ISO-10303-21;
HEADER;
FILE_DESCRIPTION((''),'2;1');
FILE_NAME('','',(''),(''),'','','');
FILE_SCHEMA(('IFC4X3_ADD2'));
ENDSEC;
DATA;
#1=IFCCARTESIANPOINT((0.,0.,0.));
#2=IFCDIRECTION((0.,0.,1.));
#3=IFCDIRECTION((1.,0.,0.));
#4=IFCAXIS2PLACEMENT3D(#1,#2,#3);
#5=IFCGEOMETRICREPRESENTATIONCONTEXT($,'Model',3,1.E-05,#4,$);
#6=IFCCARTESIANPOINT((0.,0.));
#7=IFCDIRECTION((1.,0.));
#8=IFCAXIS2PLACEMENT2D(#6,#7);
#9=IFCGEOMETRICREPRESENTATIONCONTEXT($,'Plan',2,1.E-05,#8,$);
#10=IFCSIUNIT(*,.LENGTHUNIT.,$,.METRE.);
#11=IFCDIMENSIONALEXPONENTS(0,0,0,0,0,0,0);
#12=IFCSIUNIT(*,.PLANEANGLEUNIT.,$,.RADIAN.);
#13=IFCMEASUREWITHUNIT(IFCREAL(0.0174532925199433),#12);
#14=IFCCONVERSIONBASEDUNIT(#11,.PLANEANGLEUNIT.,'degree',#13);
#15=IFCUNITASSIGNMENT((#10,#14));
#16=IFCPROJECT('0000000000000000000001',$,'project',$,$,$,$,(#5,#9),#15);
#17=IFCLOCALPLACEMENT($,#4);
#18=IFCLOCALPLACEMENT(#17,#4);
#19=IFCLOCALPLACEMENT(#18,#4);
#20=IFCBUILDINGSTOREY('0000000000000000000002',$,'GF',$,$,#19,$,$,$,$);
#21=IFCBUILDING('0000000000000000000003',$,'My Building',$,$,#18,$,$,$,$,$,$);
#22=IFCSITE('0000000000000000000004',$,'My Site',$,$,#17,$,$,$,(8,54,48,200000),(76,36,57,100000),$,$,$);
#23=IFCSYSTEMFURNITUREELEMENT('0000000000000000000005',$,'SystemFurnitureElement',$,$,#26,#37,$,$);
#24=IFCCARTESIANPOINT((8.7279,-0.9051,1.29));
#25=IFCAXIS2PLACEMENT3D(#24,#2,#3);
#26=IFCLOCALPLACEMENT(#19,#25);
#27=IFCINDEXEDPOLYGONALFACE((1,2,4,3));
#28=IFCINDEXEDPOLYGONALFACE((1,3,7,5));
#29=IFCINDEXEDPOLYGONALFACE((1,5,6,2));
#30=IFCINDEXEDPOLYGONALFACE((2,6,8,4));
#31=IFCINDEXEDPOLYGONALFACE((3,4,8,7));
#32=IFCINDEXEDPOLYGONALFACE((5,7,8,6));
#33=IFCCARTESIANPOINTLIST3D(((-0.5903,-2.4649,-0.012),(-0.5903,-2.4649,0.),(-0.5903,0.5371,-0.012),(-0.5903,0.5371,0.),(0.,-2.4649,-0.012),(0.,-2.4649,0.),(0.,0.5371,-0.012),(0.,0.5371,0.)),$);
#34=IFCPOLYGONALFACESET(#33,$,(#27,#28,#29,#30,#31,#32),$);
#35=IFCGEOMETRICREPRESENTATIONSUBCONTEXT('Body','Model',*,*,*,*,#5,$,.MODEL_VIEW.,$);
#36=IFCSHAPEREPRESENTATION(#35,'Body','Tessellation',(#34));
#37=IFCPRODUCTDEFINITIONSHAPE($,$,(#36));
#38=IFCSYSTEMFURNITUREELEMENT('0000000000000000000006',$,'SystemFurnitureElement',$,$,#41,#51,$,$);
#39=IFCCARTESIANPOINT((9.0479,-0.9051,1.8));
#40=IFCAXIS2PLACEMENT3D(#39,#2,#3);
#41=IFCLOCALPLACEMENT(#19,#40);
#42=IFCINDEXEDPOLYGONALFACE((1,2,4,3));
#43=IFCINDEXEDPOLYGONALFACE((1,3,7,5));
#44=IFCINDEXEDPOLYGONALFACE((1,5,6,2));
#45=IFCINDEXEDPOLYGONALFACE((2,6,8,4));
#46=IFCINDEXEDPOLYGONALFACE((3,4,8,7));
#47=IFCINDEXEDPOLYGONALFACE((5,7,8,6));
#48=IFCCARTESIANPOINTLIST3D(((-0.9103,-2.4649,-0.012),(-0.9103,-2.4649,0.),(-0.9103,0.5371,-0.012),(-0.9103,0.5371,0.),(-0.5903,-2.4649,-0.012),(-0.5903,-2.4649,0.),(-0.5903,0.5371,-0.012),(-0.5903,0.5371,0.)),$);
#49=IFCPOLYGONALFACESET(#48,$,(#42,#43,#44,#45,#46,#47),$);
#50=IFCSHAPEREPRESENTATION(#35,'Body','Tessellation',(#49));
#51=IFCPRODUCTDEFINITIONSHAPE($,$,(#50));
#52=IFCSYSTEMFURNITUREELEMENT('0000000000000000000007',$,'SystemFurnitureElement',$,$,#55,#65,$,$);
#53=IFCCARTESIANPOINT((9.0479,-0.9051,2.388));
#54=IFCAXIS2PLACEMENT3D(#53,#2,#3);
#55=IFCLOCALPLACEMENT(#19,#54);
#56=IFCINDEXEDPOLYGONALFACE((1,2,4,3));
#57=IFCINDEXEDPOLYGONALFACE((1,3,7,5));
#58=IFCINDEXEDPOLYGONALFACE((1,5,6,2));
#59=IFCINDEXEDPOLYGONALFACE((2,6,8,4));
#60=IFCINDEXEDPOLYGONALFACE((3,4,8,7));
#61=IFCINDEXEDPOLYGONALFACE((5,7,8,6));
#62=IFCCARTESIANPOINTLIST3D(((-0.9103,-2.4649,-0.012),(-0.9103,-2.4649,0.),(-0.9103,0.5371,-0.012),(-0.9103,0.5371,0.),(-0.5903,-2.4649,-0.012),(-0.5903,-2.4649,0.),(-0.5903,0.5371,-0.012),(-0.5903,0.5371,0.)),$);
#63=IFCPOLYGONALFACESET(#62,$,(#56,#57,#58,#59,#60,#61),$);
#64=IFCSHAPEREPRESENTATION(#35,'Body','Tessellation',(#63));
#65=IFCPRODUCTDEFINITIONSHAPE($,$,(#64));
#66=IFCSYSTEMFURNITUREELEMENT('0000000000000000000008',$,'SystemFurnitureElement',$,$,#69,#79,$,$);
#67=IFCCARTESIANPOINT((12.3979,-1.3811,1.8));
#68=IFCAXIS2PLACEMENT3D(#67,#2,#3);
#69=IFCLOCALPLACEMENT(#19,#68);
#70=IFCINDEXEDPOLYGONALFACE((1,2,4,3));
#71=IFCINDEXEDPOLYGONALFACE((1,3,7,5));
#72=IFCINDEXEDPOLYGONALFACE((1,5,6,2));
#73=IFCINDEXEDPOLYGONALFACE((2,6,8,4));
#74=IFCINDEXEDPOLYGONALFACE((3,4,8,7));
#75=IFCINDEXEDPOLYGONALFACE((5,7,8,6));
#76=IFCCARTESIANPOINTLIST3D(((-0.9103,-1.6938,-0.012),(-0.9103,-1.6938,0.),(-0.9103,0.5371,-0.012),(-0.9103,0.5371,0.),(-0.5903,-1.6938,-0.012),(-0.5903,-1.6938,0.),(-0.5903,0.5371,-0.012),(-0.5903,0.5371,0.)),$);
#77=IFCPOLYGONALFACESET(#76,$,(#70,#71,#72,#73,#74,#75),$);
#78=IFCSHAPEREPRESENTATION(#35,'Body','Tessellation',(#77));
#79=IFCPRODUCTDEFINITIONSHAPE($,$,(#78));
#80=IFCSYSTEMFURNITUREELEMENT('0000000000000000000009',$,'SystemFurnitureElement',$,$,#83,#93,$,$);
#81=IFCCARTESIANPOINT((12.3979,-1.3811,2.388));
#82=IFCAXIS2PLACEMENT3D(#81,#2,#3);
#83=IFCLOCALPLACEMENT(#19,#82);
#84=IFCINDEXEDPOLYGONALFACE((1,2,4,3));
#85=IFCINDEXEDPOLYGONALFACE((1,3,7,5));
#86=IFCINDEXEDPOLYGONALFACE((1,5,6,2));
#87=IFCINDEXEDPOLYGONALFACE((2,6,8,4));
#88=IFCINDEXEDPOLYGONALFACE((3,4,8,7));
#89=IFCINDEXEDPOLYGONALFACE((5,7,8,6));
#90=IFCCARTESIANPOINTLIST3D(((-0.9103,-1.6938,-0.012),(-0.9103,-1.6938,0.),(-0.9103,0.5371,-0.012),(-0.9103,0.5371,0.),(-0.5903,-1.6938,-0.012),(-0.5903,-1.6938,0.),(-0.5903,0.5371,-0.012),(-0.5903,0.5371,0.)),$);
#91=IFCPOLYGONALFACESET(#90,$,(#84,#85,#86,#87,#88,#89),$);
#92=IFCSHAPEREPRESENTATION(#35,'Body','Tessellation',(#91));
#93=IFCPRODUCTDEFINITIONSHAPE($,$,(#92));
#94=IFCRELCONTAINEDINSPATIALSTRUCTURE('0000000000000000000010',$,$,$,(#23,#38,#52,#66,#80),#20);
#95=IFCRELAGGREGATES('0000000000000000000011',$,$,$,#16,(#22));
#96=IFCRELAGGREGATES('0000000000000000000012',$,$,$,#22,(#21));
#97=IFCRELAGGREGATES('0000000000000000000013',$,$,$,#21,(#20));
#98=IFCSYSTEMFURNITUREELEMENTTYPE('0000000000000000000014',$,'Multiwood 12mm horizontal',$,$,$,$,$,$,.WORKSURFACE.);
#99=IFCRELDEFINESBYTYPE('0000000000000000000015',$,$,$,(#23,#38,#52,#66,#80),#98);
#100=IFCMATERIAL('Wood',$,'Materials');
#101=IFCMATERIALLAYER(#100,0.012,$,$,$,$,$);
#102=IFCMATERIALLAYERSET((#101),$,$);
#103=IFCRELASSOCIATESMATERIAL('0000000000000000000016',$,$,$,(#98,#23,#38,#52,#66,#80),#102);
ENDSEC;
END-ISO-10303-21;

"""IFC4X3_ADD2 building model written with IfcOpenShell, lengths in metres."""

from ifc_helpers import new_model, entity, si_unit, converted_unit, frame, origin_with_axes, origin_2d_with_axis, place, context, subcontext, project, spatial, indexed_curve, outline, extrude, material, layer, layer_set, layer_usage, type_object, element, save


model = new_model("IFC4X3_ADD2")

# Units and contexts
model_context = context("Model", 3, precision=1e-05, world=origin_with_axes())
plan_context = context("Plan", 2, precision=1e-05, world=origin_2d_with_axis())
body_context = subcontext(model_context, "Body", "Model", "MODEL_VIEW")
ifc_project = project(units=[si_unit("LENGTHUNIT", "METRE"), converted_unit("PLANEANGLEUNIT", "degree", entity("IfcReal", 0.0174532925199433), si_unit("PLANEANGLEUNIT", "RADIAN"), dimensions=[0, 0, 0, 0, 0, 0, 0])], contexts=[model_context, plan_context])

# Site, building, storey
site_placement = place(None, origin_with_axes())
site = spatial("IfcSite", under=ifc_project, at=site_placement, Name="My Site", RefLatitude=(8, 54, 48, 200000), RefLongitude=(76, 36, 57, 100000))
building_placement = place(site_placement, origin_with_axes())
building = spatial("IfcBuilding", under=site, at=building_placement, Name="My Building")
storey_placement = place(building_placement, origin_with_axes())
storey = spatial("IfcBuildingStorey", under=building, at=storey_placement, Name="GF")

# System furniture elements
ifc_material_1 = material(Name="Wood", Category="Materials")
ifc_layer_1 = layer(ifc_material_1, 0.012)
ifc_layer_set_1 = layer_set([ifc_layer_1])
system_furniture_element_type_1 = type_object("IfcSystemFurnitureElementType", Name="Multiwood 12mm horizontal", PredefinedType="WORKSURFACE", material=ifc_layer_set_1)
ifc_layer_usage_1 = layer_usage(ifc_layer_set_1, "AXIS3", "POSITIVE", -0.012)
system_furniture_element_1_placement = place(storey_placement, frame((8.7279, -0.9051, 1.29), z_axis=(0.0, 0.0, 1.0), x_axis=(1.0, 0.0, 0.0)))
element("IfcSystemFurnitureElement", 1, at=system_furniture_element_1_placement, inside=storey, type_object=system_furniture_element_type_1, material=ifc_layer_usage_1, Name="SystemFurnitureElement", context=body_context, shape_type="SweptSolid", body=[
    extrude(outline(indexed_curve([(0.0, 0.5371), (-0.5903, 0.5371), (-0.5903, -2.4649), (0.0, -2.4649), (0.0, 0.5371)])), frame((0.0, 0.0, -0.012), z_axis=(0.0, 0.0, 1.0), x_axis=(1.0, 0.0, 0.0)), (0.0, 0.0, 1.0), 0.012),
])
ifc_layer_usage_2 = layer_usage(ifc_layer_set_1, "AXIS3", "POSITIVE", -0.012)
system_furniture_element_2_placement = place(storey_placement, frame((9.0479, -0.9051, 1.8), z_axis=(0.0, 0.0, 1.0), x_axis=(1.0, 0.0, 0.0)))
element("IfcSystemFurnitureElement", 2, at=system_furniture_element_2_placement, inside=storey, type_object=system_furniture_element_type_1, material=ifc_layer_usage_2, Name="SystemFurnitureElement", context=body_context, shape_type="SweptSolid", body=[
    extrude(outline(indexed_curve([(-0.9103, -2.4649), (-0.5903, -2.4649), (-0.5903, 0.5371), (-0.9103, 0.5371), (-0.9103, -2.4649)])), frame((0.0, 0.0, -0.012), z_axis=(0.0, 0.0, 1.0), x_axis=(1.0, 0.0, 0.0)), (0.0, 0.0, 1.0), 0.012),
])
ifc_layer_usage_3 = layer_usage(ifc_layer_set_1, "AXIS3", "POSITIVE", -0.012)
system_furniture_element_3_placement = place(storey_placement, frame((9.0479, -0.9051, 2.388), z_axis=(0.0, 0.0, 1.0), x_axis=(1.0, 0.0, 0.0)))
element("IfcSystemFurnitureElement", 3, at=system_furniture_element_3_placement, inside=storey, type_object=system_furniture_element_type_1, material=ifc_layer_usage_3, Name="SystemFurnitureElement", context=body_context, shape_type="SweptSolid", body=[
    extrude(outline(indexed_curve([(-0.9103, -2.4649), (-0.5903, -2.4649), (-0.5903, 0.5371), (-0.9103, 0.5371), (-0.9103, -2.4649)])), frame((0.0, 0.0, -0.012), z_axis=(0.0, 0.0, 1.0), x_axis=(1.0, 0.0, 0.0)), (0.0, 0.0, 1.0), 0.012),
])
ifc_layer_usage_4 = layer_usage(ifc_layer_set_1, "AXIS3", "POSITIVE", -0.012)
system_furniture_element_4_placement = place(storey_placement, frame((12.3979, -1.3811, 1.8), z_axis=(0.0, 0.0, 1.0), x_axis=(1.0, 0.0, 0.0)))
element("IfcSystemFurnitureElement", 4, at=system_furniture_element_4_placement, inside=storey, type_object=system_furniture_element_type_1, material=ifc_layer_usage_4, Name="SystemFurnitureElement", context=body_context, shape_type="SweptSolid", body=[
    extrude(outline(indexed_curve([(-0.9103, 0.5371), (-0.5903, 0.5371), (-0.5903, -1.6938), (-0.9103, -1.6938), (-0.9103, 0.5371)])), frame((0.0, 0.0, -0.012), z_axis=(0.0, 0.0, 1.0), x_axis=(1.0, 0.0, 0.0)), (0.0, 0.0, 1.0), 0.012),
])
ifc_layer_usage_5 = layer_usage(ifc_layer_set_1, "AXIS3", "POSITIVE", -0.012)
system_furniture_element_5_placement = place(storey_placement, frame((12.3979, -1.3811, 2.388), z_axis=(0.0, 0.0, 1.0), x_axis=(1.0, 0.0, 0.0)))
element("IfcSystemFurnitureElement", 5, at=system_furniture_element_5_placement, inside=storey, type_object=system_furniture_element_type_1, material=ifc_layer_usage_5, Name="SystemFurnitureElement", context=body_context, shape_type="SweptSolid", body=[
    extrude(outline(indexed_curve([(-0.9103, 0.5371), (-0.5903, 0.5371), (-0.5903, -1.6938), (-0.9103, -1.6938), (-0.9103, 0.5371)])), frame((0.0, 0.0, -0.012), z_axis=(0.0, 0.0, 1.0), x_axis=(1.0, 0.0, 0.0)), (0.0, 0.0, 1.0), 0.012),
])

save(model, "model.ifc")
